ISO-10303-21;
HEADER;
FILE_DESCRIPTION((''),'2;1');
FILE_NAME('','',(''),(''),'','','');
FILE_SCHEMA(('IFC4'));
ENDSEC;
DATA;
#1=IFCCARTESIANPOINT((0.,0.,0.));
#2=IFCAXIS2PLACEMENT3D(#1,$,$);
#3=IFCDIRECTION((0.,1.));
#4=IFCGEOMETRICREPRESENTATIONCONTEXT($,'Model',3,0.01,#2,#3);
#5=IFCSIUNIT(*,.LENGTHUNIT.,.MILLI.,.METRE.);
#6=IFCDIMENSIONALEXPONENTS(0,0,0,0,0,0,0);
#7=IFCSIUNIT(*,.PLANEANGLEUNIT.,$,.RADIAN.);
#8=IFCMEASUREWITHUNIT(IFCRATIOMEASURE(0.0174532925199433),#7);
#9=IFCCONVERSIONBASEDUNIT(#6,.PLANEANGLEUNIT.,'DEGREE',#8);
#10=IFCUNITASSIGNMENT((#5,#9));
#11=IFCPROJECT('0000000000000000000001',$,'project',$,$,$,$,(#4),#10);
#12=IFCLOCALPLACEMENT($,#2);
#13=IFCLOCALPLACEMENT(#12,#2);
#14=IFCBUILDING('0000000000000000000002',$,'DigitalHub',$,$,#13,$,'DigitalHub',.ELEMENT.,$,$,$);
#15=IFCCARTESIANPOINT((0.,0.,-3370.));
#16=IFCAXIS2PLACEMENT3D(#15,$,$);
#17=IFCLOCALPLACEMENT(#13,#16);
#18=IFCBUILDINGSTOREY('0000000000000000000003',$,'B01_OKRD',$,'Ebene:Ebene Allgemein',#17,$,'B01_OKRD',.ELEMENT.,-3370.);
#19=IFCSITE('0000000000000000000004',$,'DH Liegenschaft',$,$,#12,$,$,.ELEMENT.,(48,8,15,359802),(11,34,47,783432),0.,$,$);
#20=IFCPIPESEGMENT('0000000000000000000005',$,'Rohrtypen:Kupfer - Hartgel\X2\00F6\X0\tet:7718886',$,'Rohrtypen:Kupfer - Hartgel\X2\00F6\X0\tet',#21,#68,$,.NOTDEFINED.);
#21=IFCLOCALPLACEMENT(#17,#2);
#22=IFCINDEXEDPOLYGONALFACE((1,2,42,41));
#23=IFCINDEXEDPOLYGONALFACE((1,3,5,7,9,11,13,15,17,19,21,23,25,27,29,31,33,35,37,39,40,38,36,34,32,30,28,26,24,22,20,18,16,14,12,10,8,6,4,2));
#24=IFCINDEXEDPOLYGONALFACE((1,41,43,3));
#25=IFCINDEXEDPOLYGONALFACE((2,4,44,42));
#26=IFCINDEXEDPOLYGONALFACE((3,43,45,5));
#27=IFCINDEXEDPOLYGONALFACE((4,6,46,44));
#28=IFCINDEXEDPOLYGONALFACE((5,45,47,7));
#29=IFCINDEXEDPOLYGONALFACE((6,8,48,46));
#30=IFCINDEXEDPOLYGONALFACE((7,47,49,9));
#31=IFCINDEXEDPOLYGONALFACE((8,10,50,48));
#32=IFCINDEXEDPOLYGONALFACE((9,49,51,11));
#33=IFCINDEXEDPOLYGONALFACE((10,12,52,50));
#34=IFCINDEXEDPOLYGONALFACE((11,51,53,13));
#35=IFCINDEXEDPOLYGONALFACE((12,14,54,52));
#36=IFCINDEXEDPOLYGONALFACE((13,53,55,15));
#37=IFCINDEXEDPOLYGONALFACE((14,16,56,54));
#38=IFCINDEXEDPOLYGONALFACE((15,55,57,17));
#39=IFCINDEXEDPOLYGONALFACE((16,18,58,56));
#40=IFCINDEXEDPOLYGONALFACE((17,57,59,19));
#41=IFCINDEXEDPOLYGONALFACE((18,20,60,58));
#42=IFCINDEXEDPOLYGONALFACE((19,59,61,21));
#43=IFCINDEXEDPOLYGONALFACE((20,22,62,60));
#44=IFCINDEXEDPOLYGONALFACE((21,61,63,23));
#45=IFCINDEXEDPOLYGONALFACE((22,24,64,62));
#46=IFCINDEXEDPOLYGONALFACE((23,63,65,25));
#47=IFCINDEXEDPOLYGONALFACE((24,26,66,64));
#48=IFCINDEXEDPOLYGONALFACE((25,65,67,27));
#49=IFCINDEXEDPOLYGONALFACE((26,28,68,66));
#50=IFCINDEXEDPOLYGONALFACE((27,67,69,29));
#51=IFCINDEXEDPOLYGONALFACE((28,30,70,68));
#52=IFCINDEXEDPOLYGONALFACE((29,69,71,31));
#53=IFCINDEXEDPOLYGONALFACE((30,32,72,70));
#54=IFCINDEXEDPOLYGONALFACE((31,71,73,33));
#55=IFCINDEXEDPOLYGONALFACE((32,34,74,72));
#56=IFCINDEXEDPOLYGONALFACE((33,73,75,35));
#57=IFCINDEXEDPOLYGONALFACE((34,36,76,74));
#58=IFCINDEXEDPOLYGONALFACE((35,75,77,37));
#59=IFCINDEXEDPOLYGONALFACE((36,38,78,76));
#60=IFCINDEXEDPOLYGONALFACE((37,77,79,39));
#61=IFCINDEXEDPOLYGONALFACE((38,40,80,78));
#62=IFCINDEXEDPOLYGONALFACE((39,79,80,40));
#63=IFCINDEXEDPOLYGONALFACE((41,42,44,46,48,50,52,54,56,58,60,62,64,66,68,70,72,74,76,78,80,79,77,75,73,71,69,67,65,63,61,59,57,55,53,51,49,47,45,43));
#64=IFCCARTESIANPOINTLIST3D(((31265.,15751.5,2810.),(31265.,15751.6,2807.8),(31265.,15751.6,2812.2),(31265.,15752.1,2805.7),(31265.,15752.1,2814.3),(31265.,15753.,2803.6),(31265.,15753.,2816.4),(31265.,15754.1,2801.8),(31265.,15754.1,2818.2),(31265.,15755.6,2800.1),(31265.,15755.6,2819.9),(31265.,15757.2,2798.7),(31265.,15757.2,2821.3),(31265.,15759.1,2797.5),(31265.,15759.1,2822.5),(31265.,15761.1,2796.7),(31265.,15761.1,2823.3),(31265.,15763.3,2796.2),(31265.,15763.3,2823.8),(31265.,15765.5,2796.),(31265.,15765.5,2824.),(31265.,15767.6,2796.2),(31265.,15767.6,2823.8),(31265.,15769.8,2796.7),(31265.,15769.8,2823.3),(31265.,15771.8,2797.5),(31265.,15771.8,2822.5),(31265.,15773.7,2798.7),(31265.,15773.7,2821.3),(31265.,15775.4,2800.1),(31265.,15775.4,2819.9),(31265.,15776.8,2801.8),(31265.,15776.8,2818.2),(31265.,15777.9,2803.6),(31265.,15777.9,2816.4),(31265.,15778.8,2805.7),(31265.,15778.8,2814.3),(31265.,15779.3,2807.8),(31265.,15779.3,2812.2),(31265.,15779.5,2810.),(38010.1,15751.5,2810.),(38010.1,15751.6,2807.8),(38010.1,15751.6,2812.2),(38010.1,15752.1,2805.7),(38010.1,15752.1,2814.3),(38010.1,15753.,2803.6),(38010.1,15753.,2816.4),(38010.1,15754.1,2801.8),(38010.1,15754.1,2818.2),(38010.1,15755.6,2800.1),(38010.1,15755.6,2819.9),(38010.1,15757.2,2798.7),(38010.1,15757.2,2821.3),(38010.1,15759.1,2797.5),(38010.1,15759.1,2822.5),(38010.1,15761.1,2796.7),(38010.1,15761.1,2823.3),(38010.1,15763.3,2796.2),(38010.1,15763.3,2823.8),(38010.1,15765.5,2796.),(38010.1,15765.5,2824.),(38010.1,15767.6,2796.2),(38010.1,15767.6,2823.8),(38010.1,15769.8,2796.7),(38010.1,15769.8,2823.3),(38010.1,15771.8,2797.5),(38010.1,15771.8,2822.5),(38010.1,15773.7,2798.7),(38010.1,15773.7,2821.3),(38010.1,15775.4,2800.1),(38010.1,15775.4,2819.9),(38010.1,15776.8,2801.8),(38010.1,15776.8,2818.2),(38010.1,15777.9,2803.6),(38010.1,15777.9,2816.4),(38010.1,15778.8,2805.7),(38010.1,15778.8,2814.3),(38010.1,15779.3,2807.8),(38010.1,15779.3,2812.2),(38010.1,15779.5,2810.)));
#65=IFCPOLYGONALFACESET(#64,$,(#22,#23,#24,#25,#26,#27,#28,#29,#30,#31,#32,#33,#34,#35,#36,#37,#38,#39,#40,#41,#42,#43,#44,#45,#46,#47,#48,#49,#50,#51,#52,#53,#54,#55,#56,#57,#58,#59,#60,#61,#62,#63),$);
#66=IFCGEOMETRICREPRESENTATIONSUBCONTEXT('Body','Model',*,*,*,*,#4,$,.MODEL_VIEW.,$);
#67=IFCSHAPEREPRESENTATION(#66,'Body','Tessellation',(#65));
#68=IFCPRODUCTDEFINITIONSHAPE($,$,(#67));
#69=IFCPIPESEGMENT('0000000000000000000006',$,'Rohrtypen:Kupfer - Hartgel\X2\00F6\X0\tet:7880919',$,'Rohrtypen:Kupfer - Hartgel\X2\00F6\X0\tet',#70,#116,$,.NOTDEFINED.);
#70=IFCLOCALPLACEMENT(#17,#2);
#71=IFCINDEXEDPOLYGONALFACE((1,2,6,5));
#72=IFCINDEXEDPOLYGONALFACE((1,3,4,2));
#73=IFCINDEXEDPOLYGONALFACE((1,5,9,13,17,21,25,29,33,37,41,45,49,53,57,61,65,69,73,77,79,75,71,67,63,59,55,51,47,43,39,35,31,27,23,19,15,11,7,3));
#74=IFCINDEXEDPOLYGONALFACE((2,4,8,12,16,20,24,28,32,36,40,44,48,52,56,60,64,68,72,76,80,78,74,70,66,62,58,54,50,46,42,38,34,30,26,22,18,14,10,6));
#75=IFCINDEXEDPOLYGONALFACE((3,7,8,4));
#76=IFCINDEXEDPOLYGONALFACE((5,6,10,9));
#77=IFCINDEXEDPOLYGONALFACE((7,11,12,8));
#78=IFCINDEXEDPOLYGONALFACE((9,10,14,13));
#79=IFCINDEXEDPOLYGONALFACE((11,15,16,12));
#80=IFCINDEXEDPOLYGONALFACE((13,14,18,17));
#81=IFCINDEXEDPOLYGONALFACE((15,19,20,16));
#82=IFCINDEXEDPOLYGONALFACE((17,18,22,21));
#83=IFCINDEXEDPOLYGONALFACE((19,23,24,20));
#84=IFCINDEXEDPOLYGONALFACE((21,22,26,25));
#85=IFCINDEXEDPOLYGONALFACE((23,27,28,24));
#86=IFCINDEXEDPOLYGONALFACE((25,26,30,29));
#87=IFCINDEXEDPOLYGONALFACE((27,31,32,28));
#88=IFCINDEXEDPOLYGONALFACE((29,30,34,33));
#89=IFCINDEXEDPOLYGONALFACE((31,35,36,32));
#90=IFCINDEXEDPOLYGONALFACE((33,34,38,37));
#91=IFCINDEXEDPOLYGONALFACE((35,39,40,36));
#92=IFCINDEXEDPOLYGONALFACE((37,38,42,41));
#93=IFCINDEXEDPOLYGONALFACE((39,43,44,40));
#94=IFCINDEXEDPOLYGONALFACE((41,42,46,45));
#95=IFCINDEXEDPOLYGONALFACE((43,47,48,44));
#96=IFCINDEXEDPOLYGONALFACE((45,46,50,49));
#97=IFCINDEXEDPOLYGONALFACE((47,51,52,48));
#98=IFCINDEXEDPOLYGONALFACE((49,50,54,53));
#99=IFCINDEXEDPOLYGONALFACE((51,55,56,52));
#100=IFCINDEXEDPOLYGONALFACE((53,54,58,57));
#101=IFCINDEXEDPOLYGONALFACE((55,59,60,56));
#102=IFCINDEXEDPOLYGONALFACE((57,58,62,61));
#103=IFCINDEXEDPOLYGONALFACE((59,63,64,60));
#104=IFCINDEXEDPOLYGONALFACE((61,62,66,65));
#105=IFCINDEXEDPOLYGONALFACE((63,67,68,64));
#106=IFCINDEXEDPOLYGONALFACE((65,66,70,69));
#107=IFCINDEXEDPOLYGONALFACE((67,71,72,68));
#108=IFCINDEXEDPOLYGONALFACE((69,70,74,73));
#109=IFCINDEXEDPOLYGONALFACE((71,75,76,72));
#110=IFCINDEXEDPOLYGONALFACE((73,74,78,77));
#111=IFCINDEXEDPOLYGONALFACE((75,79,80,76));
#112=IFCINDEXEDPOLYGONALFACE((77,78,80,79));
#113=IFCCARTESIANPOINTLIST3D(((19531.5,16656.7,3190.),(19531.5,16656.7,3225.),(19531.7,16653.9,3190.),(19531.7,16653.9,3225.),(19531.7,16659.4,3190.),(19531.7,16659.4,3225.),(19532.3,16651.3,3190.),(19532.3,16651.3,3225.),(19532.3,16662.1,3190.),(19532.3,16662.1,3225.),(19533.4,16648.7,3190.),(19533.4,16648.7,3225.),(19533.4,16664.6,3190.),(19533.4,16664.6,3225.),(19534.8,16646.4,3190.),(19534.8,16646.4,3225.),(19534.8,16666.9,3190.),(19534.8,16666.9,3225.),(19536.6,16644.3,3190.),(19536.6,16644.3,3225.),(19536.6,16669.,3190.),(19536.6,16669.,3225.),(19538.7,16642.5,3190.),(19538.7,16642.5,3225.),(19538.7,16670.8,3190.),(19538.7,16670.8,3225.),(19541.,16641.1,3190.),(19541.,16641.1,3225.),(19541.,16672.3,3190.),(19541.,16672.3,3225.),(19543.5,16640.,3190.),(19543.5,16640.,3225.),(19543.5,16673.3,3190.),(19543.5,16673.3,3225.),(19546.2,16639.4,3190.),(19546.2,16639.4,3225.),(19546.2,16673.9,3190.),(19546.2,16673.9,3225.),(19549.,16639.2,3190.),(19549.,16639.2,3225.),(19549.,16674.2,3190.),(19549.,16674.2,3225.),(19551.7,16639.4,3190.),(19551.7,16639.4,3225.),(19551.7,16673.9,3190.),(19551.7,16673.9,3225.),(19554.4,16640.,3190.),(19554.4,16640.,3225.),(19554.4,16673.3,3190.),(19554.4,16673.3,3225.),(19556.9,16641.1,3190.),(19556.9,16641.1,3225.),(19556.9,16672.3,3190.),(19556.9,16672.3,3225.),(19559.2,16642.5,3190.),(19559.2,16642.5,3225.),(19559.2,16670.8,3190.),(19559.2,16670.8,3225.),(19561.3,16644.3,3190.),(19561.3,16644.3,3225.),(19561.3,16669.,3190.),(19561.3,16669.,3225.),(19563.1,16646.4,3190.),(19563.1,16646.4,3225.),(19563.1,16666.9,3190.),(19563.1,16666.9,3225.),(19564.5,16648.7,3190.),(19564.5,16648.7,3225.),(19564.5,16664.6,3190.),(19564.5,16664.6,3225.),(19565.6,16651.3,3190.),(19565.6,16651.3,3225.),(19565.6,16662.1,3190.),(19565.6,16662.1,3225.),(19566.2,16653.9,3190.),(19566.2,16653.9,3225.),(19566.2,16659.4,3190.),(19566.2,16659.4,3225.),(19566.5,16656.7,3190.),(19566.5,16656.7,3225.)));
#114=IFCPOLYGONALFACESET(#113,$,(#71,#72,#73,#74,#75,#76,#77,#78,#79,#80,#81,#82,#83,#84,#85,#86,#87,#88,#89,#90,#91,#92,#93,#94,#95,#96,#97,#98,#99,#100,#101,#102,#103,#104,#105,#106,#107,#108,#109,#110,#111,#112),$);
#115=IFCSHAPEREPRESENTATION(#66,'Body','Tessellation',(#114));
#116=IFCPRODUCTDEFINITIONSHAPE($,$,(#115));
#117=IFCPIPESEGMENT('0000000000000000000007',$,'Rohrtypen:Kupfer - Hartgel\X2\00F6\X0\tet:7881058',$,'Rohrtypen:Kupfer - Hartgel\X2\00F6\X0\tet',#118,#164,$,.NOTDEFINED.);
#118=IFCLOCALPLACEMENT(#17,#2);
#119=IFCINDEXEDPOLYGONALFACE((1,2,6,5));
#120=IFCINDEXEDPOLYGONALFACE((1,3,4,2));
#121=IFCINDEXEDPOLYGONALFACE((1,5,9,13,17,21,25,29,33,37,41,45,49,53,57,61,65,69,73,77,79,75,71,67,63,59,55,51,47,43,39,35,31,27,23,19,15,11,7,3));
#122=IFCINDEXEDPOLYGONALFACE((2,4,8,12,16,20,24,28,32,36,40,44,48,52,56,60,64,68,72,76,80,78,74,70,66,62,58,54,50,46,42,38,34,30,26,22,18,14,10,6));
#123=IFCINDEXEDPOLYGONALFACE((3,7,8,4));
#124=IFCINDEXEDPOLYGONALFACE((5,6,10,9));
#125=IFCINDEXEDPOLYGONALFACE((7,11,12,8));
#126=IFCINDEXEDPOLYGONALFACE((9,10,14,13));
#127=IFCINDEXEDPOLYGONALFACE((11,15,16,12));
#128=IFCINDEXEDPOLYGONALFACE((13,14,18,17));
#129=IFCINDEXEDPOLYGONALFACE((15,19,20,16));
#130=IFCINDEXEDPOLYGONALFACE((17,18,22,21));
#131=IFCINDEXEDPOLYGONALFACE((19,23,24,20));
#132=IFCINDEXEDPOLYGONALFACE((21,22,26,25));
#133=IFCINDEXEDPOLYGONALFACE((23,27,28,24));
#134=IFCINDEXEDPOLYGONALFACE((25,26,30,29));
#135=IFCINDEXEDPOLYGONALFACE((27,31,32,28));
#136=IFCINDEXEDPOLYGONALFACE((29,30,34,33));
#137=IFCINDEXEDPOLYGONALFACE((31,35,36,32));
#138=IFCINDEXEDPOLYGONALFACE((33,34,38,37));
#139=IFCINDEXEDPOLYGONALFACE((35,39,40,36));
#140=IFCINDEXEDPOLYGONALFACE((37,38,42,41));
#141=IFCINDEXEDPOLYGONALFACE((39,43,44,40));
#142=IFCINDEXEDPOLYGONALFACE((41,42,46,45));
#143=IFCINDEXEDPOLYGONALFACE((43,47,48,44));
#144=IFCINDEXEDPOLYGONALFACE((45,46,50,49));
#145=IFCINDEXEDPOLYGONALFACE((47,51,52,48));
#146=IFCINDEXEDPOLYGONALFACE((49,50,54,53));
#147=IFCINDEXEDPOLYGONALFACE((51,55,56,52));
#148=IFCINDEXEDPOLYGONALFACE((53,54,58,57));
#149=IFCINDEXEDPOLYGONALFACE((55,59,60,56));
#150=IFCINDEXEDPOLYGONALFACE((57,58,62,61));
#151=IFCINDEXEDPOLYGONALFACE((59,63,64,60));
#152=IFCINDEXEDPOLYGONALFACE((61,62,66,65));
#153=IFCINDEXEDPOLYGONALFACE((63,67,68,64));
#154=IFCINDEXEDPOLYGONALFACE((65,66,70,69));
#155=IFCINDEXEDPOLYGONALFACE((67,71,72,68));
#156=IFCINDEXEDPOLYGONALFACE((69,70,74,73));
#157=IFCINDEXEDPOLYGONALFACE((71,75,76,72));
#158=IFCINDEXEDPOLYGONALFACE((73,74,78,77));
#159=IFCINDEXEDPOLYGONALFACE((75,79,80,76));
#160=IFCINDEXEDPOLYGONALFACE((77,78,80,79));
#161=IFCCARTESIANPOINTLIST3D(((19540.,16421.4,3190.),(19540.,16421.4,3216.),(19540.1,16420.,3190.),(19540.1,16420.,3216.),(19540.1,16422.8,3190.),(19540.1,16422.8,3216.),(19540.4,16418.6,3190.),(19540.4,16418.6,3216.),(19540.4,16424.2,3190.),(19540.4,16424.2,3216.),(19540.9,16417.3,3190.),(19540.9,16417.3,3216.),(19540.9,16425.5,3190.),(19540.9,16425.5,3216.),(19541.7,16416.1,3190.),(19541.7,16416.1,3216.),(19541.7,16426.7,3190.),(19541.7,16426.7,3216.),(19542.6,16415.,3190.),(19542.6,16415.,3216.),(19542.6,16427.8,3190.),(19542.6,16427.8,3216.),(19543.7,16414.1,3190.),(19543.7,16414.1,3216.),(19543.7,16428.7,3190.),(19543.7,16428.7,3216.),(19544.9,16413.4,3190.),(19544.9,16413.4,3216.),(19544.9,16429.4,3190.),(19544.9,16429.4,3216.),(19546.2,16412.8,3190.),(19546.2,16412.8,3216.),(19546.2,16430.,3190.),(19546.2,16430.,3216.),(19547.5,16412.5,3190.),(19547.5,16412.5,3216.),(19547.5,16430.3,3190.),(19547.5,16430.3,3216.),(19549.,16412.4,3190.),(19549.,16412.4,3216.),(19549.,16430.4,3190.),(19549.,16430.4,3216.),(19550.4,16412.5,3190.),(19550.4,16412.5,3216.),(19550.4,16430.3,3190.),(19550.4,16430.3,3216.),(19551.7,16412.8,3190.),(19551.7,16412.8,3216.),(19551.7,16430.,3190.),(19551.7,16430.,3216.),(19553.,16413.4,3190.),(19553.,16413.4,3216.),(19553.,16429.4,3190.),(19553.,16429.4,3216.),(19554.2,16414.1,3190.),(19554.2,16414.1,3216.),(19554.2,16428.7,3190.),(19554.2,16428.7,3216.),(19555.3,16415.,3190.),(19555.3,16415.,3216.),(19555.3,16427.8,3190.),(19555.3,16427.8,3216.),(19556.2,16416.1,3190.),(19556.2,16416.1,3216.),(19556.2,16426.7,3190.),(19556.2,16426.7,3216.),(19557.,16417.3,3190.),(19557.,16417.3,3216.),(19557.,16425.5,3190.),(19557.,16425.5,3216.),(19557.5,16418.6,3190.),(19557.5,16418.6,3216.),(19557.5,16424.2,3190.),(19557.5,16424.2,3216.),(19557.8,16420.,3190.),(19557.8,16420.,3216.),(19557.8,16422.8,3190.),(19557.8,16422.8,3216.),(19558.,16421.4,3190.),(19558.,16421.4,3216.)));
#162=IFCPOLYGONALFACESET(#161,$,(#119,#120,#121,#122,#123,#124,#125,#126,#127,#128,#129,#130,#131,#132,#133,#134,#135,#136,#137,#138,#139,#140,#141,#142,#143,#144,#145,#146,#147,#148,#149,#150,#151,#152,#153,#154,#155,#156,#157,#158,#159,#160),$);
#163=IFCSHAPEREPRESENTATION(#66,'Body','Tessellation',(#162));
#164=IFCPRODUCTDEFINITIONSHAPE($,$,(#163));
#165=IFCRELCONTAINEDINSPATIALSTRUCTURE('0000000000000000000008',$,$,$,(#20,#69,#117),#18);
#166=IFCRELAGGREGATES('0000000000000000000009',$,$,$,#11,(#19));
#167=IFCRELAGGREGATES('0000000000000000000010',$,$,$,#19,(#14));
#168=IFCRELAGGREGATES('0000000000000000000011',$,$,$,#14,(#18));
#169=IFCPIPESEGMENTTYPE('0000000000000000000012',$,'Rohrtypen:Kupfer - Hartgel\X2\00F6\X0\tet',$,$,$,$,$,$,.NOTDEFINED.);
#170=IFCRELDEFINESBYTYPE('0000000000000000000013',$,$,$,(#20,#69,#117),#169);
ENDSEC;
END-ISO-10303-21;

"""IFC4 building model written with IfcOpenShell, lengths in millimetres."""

from ifc_helpers import new_model, entity, si_unit, converted_unit, direction, frame, origin, place, context, subcontext, project, spatial, indexed_curve, outline, extrude, type_object, element, save


model = new_model("IFC4")

# Units and contexts
model_context = context("Model", 3, precision=0.01, world=origin(), true_north=direction((0.0, 1.0)))
body_context = subcontext(model_context, "Body", "Model", "MODEL_VIEW")
ifc_project = project(units=[si_unit("LENGTHUNIT", "METRE", prefix="MILLI"), converted_unit("PLANEANGLEUNIT", "DEGREE", entity("IfcRatioMeasure", 0.0174532925199433), si_unit("PLANEANGLEUNIT", "RADIAN"), dimensions=[0, 0, 0, 0, 0, 0, 0])], contexts=[model_context])

# Site, building, storey
site_placement = place(None, origin())
site = spatial("IfcSite", under=ifc_project, at=site_placement, Name="DH Liegenschaft", CompositionType="ELEMENT", RefLatitude=(48, 8, 15, 359802), RefLongitude=(11, 34, 47, 783432), RefElevation=0.0)
building_placement = place(site_placement, origin())
building = spatial("IfcBuilding", under=site, at=building_placement, Name="DigitalHub", LongName="DigitalHub", CompositionType="ELEMENT")
storey_placement = place(building_placement, frame((0.0, 0.0, -3370.0)))
storey = spatial("IfcBuildingStorey", under=building, at=storey_placement, Name="B01_OKRD", ObjectType="Ebene:Ebene Allgemein", LongName="B01_OKRD", CompositionType="ELEMENT", Elevation=-3370.0)

# Pipe segments
pipe_segment_type = type_object("IfcPipeSegmentType", Name="Rohrtypen:Kupfer - Hartgelötet", PredefinedType="NOTDEFINED")
pipe_segment_1_placement = place(storey_placement, frame((31265.0, 15749.9, 2794.4)))
element("IfcPipeSegment", 1, at=pipe_segment_1_placement, inside=storey, type_object=pipe_segment_type, Name="Rohrtypen:Kupfer - Hartgelötet:7718886", ObjectType="Rohrtypen:Kupfer - Hartgelötet", PredefinedType="NOTDEFINED", context=body_context, shape_type="SweptSolid", body=[
    extrude(outline(indexed_curve([(14.0, 0.0), (13.8, 2.2), (13.3, 4.3), (12.5, 6.4), (11.3, 8.2), (9.9, 9.9), (8.2, 11.3), (6.4, 12.5), (4.3, 13.3), (2.2, 13.8), (0.0, 14.0), (-2.2, 13.8), (-4.3, 13.3), (-6.4, 12.5), (-8.2, 11.3), (-9.9, 9.9), (-11.3, 8.2), (-12.5, 6.4), (-13.3, 4.3), (-13.8, 2.2), (-14.0, 0.0), (-13.8, -2.2), (-13.3, -4.3), (-12.5, -6.4), (-11.3, -8.2), (-9.9, -9.9), (-8.2, -11.3), (-6.4, -12.5), (-4.3, -13.3), (-2.2, -13.8), (0.0, -14.0), (2.2, -13.8), (4.3, -13.3), (6.4, -12.5), (8.2, -11.3), (9.9, -9.9), (11.3, -8.2), (12.5, -6.4), (13.3, -4.3), (13.8, -2.2), (14.0, 0.0)], self_intersect=False)), frame((0.0, 15.6, 15.6), z_axis=(1.0, 0.0, 0.0), x_axis=(0.0, 1.0, 0.0)), (0.0, 0.0, 1.0), 6745.1),
])
pipe_segment_2_placement = place(storey_placement, frame((19529.9, 16637.6, 3190.0)))
element("IfcPipeSegment", 2, at=pipe_segment_2_placement, inside=storey, type_object=pipe_segment_type, Name="Rohrtypen:Kupfer - Hartgelötet:7880919", ObjectType="Rohrtypen:Kupfer - Hartgelötet", PredefinedType="NOTDEFINED", context=body_context, shape_type="SweptSolid", body=[
    extrude(outline(indexed_curve([(17.5, 0.0), (17.3, 2.7), (16.6, 5.4), (15.6, 7.9), (14.2, 10.3), (12.4, 12.4), (10.3, 14.2), (7.9, 15.6), (5.4, 16.6), (2.7, 17.3), (0.0, 17.5), (-2.7, 17.3), (-5.4, 16.6), (-7.9, 15.6), (-10.3, 14.2), (-12.4, 12.4), (-14.2, 10.3), (-15.6, 7.9), (-16.6, 5.4), (-17.3, 2.7), (-17.5, 0.0), (-17.3, -2.7), (-16.6, -5.4), (-15.6, -7.9), (-14.2, -10.3), (-12.4, -12.4), (-10.3, -14.2), (-7.9, -15.6), (-5.4, -16.6), (-2.7, -17.3), (0.0, -17.5), (2.7, -17.3), (5.4, -16.6), (7.9, -15.6), (10.3, -14.2), (12.4, -12.4), (14.2, -10.3), (15.6, -7.9), (16.6, -5.4), (17.3, -2.7), (17.5, 0.0)], self_intersect=False)), frame((19.1, 19.1, 0.0), z_axis=(0.0, 0.0, 1.0), x_axis=(-1.0, 0.0, 0.0)), (0.0, 0.0, 1.0), 35.0),
])
pipe_segment_3_placement = place(storey_placement, frame((19538.4, 16410.8, 3190.0)))
element("IfcPipeSegment", 3, at=pipe_segment_3_placement, inside=storey, type_object=pipe_segment_type, Name="Rohrtypen:Kupfer - Hartgelötet:7881058", ObjectType="Rohrtypen:Kupfer - Hartgelötet", PredefinedType="NOTDEFINED", context=body_context, shape_type="SweptSolid", body=[
    extrude(outline(indexed_curve([(9.0, 0.0), (8.9, 1.4), (8.6, 2.8), (8.0, 4.1), (7.3, 5.3), (6.4, 6.4), (5.3, 7.3), (4.1, 8.0), (2.8, 8.6), (1.4, 8.9), (0.0, 9.0), (-1.4, 8.9), (-2.8, 8.6), (-4.1, 8.0), (-5.3, 7.3), (-6.4, 6.4), (-7.3, 5.3), (-8.0, 4.1), (-8.6, 2.8), (-8.9, 1.4), (-9.0, 0.0), (-8.9, -1.4), (-8.6, -2.8), (-8.0, -4.1), (-7.3, -5.3), (-6.4, -6.4), (-5.3, -7.3), (-4.1, -8.0), (-2.8, -8.6), (-1.4, -8.9), (0.0, -9.0), (1.4, -8.9), (2.8, -8.6), (4.1, -8.0), (5.3, -7.3), (6.4, -6.4), (7.3, -5.3), (8.0, -4.1), (8.6, -2.8), (8.9, -1.4), (9.0, 0.0)], self_intersect=False)), frame((10.6, 10.6, 0.0)), (0.0, 0.0, 1.0), 26.0),
])

save(model, "model.ifc")
